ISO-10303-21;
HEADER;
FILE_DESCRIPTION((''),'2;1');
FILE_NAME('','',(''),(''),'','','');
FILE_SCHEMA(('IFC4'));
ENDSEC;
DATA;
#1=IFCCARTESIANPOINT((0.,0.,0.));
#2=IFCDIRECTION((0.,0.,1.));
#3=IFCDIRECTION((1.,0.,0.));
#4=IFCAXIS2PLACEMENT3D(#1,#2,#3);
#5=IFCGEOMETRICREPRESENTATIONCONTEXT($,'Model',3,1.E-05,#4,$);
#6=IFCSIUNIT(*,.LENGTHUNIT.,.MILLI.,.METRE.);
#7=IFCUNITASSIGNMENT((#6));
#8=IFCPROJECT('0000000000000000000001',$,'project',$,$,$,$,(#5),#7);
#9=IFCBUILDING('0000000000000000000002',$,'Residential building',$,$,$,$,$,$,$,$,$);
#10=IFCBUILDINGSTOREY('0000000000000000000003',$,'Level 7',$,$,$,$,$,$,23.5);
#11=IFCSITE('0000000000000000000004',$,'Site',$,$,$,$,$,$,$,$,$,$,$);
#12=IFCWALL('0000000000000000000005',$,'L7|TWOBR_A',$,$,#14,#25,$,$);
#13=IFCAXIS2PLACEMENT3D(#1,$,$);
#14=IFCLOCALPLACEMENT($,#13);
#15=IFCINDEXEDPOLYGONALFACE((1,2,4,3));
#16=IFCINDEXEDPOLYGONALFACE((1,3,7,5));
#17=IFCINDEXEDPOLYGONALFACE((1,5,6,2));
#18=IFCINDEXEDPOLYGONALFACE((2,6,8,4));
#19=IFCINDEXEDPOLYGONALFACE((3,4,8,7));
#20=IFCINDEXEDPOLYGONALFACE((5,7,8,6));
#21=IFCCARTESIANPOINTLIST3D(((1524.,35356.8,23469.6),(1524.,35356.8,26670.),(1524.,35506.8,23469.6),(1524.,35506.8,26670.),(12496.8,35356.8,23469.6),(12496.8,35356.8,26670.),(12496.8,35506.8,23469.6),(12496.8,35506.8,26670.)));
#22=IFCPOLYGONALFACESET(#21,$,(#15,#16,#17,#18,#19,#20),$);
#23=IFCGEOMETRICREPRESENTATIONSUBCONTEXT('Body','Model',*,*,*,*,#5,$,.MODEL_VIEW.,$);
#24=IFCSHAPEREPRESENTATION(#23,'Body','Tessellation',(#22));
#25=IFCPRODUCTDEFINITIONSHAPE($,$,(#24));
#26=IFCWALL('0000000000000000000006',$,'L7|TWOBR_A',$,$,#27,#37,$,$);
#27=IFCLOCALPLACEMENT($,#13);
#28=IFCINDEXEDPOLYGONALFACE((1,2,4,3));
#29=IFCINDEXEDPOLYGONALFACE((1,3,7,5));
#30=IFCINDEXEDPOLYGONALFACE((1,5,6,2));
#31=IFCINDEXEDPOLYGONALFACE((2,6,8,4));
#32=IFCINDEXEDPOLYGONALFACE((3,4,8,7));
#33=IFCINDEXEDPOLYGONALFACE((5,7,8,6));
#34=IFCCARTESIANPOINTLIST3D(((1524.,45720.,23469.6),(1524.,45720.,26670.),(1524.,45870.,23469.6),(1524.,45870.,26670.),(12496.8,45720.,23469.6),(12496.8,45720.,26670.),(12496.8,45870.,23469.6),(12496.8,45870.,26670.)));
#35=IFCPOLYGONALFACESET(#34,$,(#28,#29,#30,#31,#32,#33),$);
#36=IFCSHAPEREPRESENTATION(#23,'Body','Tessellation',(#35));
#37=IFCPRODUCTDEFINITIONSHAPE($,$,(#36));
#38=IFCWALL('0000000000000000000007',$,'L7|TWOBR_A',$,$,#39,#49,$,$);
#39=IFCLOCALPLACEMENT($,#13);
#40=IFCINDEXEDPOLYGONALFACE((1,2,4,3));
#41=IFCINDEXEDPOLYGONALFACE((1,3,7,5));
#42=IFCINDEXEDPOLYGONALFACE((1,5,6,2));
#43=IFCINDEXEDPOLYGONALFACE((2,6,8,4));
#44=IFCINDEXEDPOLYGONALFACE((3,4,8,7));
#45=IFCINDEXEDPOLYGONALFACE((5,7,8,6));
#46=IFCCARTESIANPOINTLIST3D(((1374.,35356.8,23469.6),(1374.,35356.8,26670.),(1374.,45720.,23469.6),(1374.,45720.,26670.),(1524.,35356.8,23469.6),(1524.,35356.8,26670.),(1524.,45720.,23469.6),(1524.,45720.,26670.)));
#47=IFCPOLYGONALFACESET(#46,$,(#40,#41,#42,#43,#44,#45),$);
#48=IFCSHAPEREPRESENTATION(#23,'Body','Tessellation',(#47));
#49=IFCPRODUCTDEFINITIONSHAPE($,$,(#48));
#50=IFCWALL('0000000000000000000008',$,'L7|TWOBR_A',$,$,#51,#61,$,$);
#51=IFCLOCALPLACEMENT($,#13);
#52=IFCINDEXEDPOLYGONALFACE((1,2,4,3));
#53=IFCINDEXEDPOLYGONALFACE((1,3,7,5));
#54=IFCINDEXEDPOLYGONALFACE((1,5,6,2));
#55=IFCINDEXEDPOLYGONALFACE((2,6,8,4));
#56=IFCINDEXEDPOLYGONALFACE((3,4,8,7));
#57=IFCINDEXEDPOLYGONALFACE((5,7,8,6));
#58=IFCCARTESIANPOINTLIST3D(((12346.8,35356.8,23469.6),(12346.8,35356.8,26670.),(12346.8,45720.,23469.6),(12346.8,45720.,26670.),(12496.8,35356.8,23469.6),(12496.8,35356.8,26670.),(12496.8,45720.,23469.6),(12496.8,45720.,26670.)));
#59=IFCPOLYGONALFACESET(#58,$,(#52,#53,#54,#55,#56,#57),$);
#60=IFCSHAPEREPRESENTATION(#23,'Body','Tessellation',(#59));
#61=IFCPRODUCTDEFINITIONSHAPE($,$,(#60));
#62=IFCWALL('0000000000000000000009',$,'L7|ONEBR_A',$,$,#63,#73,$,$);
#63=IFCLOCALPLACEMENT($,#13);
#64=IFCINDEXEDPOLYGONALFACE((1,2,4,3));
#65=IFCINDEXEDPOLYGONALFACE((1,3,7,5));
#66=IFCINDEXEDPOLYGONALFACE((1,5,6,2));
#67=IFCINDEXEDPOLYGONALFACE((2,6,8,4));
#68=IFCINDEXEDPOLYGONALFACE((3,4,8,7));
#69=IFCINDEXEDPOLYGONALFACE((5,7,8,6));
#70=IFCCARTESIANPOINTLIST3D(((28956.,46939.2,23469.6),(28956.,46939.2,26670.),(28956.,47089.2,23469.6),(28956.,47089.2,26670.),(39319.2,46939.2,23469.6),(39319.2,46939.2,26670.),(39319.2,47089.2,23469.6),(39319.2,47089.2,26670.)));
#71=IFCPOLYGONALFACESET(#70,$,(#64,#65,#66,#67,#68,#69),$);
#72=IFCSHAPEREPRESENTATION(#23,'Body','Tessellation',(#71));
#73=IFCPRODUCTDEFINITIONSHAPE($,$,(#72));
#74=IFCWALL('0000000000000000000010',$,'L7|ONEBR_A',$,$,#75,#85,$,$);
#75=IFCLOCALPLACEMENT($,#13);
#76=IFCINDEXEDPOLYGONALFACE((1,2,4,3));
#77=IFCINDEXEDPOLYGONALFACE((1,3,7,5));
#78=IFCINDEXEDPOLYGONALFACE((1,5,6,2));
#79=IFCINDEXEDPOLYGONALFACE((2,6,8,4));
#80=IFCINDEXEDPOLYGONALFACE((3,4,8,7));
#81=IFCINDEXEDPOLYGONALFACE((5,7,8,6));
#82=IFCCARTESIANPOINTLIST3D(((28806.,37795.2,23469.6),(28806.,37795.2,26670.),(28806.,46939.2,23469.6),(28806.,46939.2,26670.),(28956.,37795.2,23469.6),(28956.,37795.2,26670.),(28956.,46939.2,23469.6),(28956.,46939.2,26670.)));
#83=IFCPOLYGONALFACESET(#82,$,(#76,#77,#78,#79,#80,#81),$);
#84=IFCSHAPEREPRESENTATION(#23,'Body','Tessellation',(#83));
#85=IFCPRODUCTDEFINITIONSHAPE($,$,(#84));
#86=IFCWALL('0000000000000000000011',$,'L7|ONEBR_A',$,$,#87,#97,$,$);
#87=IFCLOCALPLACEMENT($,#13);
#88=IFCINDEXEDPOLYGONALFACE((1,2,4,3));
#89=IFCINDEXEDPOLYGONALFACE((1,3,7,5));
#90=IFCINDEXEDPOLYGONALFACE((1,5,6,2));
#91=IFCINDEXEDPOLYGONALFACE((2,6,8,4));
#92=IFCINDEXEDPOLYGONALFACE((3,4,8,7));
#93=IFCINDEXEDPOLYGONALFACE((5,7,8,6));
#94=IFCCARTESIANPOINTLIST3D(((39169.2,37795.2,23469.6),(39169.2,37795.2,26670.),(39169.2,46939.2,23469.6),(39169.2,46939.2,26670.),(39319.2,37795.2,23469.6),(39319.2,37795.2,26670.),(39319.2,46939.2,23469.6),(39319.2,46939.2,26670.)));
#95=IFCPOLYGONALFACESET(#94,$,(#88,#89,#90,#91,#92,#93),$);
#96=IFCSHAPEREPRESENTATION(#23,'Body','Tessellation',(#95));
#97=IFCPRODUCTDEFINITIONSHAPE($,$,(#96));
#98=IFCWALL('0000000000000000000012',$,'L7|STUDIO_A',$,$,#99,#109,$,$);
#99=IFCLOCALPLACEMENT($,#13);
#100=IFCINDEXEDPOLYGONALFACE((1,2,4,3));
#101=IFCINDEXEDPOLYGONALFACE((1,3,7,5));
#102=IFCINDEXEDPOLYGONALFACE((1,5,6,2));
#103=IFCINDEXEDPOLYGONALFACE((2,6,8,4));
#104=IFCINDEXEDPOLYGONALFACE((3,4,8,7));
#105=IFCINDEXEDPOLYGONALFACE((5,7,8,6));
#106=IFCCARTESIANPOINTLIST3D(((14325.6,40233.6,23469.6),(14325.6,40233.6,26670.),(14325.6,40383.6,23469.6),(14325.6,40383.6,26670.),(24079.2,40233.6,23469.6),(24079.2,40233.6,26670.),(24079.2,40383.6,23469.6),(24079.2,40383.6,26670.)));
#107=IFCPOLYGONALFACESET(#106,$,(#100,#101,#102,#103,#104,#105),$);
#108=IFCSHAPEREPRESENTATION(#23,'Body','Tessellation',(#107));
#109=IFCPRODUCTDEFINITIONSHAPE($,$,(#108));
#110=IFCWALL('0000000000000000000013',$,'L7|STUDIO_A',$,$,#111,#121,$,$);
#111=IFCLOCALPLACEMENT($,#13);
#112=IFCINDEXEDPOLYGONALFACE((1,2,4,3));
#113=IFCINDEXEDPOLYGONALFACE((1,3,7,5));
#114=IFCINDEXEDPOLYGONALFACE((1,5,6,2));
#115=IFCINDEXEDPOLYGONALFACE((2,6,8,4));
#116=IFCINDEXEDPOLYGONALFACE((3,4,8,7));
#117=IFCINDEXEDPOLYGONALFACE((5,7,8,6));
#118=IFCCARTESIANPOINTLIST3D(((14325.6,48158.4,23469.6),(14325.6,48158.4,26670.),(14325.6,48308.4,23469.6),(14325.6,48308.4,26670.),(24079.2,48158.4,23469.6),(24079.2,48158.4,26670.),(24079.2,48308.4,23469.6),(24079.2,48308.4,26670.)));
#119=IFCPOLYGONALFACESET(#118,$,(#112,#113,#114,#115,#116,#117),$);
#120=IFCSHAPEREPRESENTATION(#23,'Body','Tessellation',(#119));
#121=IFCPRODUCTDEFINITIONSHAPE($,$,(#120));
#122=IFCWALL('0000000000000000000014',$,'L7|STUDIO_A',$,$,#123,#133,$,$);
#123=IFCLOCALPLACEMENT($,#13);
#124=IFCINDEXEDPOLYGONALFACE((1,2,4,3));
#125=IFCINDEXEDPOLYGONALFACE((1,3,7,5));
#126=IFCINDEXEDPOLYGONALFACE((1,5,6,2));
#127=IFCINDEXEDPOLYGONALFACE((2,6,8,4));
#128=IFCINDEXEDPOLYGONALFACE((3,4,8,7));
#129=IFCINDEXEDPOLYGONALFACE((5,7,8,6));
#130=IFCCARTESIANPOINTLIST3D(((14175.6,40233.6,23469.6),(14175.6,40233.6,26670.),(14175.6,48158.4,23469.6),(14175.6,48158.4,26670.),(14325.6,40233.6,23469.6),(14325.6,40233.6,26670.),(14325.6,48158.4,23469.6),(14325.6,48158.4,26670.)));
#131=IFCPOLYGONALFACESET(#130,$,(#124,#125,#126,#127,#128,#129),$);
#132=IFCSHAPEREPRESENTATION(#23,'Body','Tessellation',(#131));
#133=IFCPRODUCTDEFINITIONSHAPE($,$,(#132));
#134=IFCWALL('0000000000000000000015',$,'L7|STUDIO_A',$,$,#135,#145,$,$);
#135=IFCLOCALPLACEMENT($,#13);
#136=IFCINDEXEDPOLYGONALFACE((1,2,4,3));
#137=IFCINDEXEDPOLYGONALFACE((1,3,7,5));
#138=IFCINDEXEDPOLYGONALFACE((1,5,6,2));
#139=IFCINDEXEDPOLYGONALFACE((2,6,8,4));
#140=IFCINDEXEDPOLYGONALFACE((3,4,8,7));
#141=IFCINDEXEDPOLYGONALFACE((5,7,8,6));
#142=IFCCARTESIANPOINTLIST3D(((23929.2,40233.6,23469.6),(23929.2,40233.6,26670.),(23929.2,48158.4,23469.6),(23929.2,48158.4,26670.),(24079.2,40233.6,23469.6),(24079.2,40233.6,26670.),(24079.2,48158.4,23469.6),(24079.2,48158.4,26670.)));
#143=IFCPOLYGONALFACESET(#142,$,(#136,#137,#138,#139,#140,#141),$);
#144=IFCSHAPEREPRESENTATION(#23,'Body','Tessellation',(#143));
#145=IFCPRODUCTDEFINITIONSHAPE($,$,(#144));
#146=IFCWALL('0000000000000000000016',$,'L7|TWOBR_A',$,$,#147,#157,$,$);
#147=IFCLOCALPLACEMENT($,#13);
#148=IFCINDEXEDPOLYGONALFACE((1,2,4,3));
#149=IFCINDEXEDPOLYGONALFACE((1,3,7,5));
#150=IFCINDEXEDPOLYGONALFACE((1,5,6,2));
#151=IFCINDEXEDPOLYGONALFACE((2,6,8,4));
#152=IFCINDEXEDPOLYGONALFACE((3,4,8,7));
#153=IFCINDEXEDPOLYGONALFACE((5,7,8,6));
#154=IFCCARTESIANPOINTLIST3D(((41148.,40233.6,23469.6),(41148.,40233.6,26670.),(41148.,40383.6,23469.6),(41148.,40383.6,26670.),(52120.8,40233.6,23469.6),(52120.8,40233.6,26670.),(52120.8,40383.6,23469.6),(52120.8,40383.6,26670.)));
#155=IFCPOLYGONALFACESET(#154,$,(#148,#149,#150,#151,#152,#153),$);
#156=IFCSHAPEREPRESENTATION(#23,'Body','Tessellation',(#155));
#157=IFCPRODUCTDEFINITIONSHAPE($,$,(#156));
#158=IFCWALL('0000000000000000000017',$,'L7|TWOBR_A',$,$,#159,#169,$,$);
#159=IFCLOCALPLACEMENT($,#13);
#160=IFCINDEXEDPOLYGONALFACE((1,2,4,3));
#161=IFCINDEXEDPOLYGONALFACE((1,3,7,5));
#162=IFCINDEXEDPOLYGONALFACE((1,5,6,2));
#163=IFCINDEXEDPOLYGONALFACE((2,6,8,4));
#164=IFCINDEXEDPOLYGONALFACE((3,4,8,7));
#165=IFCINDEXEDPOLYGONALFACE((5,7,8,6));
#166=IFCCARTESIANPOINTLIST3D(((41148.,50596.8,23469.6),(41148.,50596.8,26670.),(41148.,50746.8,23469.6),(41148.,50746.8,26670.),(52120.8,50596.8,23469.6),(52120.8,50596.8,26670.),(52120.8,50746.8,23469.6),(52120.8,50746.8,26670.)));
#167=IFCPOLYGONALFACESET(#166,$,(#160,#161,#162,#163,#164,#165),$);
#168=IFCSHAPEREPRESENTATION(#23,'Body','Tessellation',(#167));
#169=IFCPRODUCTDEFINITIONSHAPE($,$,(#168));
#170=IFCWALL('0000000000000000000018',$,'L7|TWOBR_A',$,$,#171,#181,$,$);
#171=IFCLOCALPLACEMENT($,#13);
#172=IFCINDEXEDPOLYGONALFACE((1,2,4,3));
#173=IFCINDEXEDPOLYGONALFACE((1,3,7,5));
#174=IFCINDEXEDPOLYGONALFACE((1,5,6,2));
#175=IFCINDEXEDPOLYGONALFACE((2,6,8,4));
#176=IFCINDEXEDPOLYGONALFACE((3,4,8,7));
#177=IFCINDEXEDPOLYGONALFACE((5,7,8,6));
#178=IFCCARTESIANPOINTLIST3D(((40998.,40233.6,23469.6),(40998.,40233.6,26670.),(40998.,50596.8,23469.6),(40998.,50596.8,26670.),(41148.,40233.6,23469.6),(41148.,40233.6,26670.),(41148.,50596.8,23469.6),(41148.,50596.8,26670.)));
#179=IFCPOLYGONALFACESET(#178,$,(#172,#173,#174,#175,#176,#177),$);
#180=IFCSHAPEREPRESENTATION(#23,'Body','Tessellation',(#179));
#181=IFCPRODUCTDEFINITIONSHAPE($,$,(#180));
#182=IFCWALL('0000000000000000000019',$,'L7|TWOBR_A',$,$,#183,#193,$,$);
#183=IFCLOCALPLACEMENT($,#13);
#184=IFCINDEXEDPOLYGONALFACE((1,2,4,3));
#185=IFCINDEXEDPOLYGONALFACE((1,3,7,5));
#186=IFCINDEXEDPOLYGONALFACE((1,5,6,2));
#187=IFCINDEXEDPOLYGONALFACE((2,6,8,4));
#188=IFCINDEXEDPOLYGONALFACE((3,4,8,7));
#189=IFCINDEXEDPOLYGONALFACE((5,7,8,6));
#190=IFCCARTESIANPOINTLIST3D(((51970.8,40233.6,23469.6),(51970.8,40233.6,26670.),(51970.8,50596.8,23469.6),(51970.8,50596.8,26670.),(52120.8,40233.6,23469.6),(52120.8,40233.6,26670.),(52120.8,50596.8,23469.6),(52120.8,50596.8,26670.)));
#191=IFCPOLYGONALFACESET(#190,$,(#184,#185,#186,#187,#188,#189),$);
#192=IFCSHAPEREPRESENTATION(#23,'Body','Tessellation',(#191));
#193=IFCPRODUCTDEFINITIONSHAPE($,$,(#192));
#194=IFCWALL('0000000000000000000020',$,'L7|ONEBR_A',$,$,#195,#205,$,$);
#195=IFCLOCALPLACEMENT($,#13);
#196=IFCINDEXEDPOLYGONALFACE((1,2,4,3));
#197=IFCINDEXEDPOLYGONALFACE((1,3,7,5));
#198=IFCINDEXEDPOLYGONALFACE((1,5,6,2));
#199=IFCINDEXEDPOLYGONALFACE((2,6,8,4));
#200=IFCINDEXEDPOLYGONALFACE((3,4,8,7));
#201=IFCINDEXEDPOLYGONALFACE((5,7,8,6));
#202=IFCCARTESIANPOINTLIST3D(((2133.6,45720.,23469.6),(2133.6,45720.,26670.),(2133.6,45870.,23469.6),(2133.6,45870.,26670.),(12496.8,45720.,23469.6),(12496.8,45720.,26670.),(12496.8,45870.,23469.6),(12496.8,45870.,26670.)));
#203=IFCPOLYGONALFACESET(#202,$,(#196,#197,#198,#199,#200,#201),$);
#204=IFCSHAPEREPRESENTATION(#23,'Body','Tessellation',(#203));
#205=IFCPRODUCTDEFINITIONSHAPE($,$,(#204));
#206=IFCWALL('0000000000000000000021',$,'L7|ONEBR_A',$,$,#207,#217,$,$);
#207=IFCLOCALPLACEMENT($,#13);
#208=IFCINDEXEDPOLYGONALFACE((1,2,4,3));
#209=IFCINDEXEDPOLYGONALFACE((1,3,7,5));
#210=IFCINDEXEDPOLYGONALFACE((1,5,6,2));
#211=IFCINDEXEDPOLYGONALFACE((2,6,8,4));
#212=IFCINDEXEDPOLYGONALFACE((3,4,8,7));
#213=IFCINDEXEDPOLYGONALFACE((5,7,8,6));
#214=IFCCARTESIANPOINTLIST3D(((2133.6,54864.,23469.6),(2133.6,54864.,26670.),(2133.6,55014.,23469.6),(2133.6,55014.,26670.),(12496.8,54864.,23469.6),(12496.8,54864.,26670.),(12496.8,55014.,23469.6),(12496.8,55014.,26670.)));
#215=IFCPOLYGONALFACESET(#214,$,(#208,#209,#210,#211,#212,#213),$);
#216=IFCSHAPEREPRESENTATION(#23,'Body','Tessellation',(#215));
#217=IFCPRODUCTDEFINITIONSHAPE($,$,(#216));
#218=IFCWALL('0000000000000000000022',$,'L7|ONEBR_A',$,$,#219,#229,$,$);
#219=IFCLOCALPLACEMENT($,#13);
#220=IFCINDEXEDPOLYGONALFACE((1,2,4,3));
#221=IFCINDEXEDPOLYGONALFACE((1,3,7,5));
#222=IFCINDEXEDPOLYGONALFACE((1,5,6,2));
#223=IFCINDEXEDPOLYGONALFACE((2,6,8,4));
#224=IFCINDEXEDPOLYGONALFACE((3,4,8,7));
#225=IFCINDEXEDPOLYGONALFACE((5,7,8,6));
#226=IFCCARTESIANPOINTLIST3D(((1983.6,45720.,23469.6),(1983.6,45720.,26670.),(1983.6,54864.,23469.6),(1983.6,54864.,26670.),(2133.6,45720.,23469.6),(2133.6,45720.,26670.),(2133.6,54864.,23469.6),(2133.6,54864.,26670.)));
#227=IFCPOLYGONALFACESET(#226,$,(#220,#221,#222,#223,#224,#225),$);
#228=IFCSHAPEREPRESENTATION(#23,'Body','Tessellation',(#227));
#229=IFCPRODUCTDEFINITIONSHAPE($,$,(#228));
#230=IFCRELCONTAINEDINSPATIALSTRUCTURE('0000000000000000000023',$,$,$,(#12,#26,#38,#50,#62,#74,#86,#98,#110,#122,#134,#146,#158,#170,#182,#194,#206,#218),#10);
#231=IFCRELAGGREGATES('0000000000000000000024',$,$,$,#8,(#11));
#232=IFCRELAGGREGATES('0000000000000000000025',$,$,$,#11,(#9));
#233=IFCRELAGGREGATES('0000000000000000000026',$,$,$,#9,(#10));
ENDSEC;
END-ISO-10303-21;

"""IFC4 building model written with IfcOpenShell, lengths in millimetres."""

from ifc_helpers import new_model, si_unit, frame, origin_with_axes, place, context, subcontext, project, spatial, indexed_curve, outline, extrude, element, save


model = new_model("IFC4")

# Units and contexts
model_context = context("Model", 3, precision=1e-05, world=origin_with_axes())
body_context = subcontext(model_context, "Body", "Model", "MODEL_VIEW")
ifc_project = project(units=[si_unit("LENGTHUNIT", "METRE", prefix="MILLI")], contexts=[model_context])

# Site, building, storey
site = spatial("IfcSite", under=ifc_project, Name="Site")
building = spatial("IfcBuilding", under=site, Name="Residential building")
storey = spatial("IfcBuildingStorey", under=building, Name="Level 7", Elevation=23.5)

# Walls
for number, where, z_axis, x_axis, name in (
    (1, (1524.0, 35356.8, 23469.6), (0.0, 0.0, 1.0), (1.0, 0.0, 0.0), "L7|TWOBR_A"),
    (2, (1524.0, 45720.0, 23469.6), (0.0, 0.0, 1.0), (1.0, 0.0, 0.0), "L7|TWOBR_A"),
):
    element("IfcWall", number, at=place(None, frame(where, z_axis=z_axis, x_axis=x_axis)), inside=storey, Name=name, context=body_context, shape_type="SweptSolid", body=[
        extrude(outline(indexed_curve([(0.0, 0.0), (0.0, 150.0), (10972.8, 150.0), (10972.8, 0.0), (0.0, 0.0)], self_intersect=False)), origin_with_axes(), (0.0, 0.0, 1.0), 3200.4),
    ])
for number, where, z_axis, x_axis, name in (
    (3, (1524.0, 35356.8, 23469.6), (0.0, 0.0, 1.0), (0.0, 1.0, 0.0), "L7|TWOBR_A"),
    (4, (12496.8, 35356.8, 23469.6), (0.0, 0.0, 1.0), (0.0, 1.0, 0.0), "L7|TWOBR_A"),
    (5, (28956.0, 46939.2, 23469.6), (0.0, 0.0, 1.0), (1.0, 0.0, 0.0), "L7|ONEBR_A"),
):
    element("IfcWall", number, at=place(None, frame(where, z_axis=z_axis, x_axis=x_axis)), inside=storey, Name=name, context=body_context, shape_type="SweptSolid", body=[
        extrude(outline(indexed_curve([(0.0, 0.0), (0.0, 150.0), (10363.2, 150.0), (10363.2, 0.0), (0.0, 0.0)], self_intersect=False)), origin_with_axes(), (0.0, 0.0, 1.0), 3200.4),
    ])
for number, where, z_axis, x_axis, name in (
    (6, (28956.0, 37795.2, 23469.6), (0.0, 0.0, 1.0), (0.0, 1.0, 0.0), "L7|ONEBR_A"),
    (7, (39319.2, 37795.2, 23469.6), (0.0, 0.0, 1.0), (0.0, 1.0, 0.0), "L7|ONEBR_A"),
):
    element("IfcWall", number, at=place(None, frame(where, z_axis=z_axis, x_axis=x_axis)), inside=storey, Name=name, context=body_context, shape_type="SweptSolid", body=[
        extrude(outline(indexed_curve([(0.0, 0.0), (0.0, 150.0), (9144.0, 150.0), (9144.0, 0.0), (0.0, 0.0)], self_intersect=False)), origin_with_axes(), (0.0, 0.0, 1.0), 3200.4),
    ])
for number, where, z_axis, x_axis, name in (
    (8, (14325.6, 40233.6, 23469.6), (0.0, 0.0, 1.0), (1.0, 0.0, 0.0), "L7|STUDIO_A"),
    (9, (14325.6, 48158.4, 23469.6), (0.0, 0.0, 1.0), (1.0, 0.0, 0.0), "L7|STUDIO_A"),
):
    element("IfcWall", number, at=place(None, frame(where, z_axis=z_axis, x_axis=x_axis)), inside=storey, Name=name, context=body_context, shape_type="SweptSolid", body=[
        extrude(outline(indexed_curve([(0.0, 0.0), (0.0, 150.0), (9753.6, 150.0), (9753.6, 0.0), (0.0, 0.0)], self_intersect=False)), origin_with_axes(), (0.0, 0.0, 1.0), 3200.4),
    ])
for number, where, z_axis, x_axis, name in (
    (10, (14325.6, 40233.6, 23469.6), (0.0, 0.0, 1.0), (0.0, 1.0, 0.0), "L7|STUDIO_A"),
    (11, (24079.2, 40233.6, 23469.6), (0.0, 0.0, 1.0), (0.0, 1.0, 0.0), "L7|STUDIO_A"),
):
    element("IfcWall", number, at=place(None, frame(where, z_axis=z_axis, x_axis=x_axis)), inside=storey, Name=name, context=body_context, shape_type="SweptSolid", body=[
        extrude(outline(indexed_curve([(0.0, 0.0), (0.0, 150.0), (7924.8, 150.0), (7924.8, 0.0), (0.0, 0.0)], self_intersect=False)), origin_with_axes(), (0.0, 0.0, 1.0), 3200.4),
    ])
for number, where, z_axis, x_axis, name in (
    (12, (41148.0, 40233.6, 23469.6), (0.0, 0.0, 1.0), (1.0, 0.0, 0.0), "L7|TWOBR_A"),
    (13, (41148.0, 50596.8, 23469.6), (0.0, 0.0, 1.0), (1.0, 0.0, 0.0), "L7|TWOBR_A"),
):
    element("IfcWall", number, at=place(None, frame(where, z_axis=z_axis, x_axis=x_axis)), inside=storey, Name=name, context=body_context, shape_type="SweptSolid", body=[
        extrude(outline(indexed_curve([(0.0, 0.0), (0.0, 150.0), (10972.8, 150.0), (10972.8, 0.0), (0.0, 0.0)], self_intersect=False)), origin_with_axes(), (0.0, 0.0, 1.0), 3200.4),
    ])
for number, where, z_axis, x_axis, name in (
    (14, (41148.0, 40233.6, 23469.6), (0.0, 0.0, 1.0), (0.0, 1.0, 0.0), "L7|TWOBR_A"),
    (15, (52120.8, 40233.6, 23469.6), (0.0, 0.0, 1.0), (0.0, 1.0, 0.0), "L7|TWOBR_A"),
    (16, (2133.6, 45720.0, 23469.6), (0.0, 0.0, 1.0), (1.0, 0.0, 0.0), "L7|ONEBR_A"),
    (17, (2133.6, 54864.0, 23469.6), (0.0, 0.0, 1.0), (1.0, 0.0, 0.0), "L7|ONEBR_A"),
):
    element("IfcWall", number, at=place(None, frame(where, z_axis=z_axis, x_axis=x_axis)), inside=storey, Name=name, context=body_context, shape_type="SweptSolid", body=[
        extrude(outline(indexed_curve([(0.0, 0.0), (0.0, 150.0), (10363.2, 150.0), (10363.2, 0.0), (0.0, 0.0)], self_intersect=False)), origin_with_axes(), (0.0, 0.0, 1.0), 3200.4),
    ])
for number, where, z_axis, x_axis, name in (
    (18, (2133.6, 45720.0, 23469.6), (0.0, 0.0, 1.0), (0.0, 1.0, 0.0), "L7|ONEBR_A"),
):
    element("IfcWall", number, at=place(None, frame(where, z_axis=z_axis, x_axis=x_axis)), inside=storey, Name=name, context=body_context, shape_type="SweptSolid", body=[
        extrude(outline(indexed_curve([(0.0, 0.0), (0.0, 150.0), (9144.0, 150.0), (9144.0, 0.0), (0.0, 0.0)], self_intersect=False)), origin_with_axes(), (0.0, 0.0, 1.0), 3200.4),
    ])

save(model, "model.ifc")
